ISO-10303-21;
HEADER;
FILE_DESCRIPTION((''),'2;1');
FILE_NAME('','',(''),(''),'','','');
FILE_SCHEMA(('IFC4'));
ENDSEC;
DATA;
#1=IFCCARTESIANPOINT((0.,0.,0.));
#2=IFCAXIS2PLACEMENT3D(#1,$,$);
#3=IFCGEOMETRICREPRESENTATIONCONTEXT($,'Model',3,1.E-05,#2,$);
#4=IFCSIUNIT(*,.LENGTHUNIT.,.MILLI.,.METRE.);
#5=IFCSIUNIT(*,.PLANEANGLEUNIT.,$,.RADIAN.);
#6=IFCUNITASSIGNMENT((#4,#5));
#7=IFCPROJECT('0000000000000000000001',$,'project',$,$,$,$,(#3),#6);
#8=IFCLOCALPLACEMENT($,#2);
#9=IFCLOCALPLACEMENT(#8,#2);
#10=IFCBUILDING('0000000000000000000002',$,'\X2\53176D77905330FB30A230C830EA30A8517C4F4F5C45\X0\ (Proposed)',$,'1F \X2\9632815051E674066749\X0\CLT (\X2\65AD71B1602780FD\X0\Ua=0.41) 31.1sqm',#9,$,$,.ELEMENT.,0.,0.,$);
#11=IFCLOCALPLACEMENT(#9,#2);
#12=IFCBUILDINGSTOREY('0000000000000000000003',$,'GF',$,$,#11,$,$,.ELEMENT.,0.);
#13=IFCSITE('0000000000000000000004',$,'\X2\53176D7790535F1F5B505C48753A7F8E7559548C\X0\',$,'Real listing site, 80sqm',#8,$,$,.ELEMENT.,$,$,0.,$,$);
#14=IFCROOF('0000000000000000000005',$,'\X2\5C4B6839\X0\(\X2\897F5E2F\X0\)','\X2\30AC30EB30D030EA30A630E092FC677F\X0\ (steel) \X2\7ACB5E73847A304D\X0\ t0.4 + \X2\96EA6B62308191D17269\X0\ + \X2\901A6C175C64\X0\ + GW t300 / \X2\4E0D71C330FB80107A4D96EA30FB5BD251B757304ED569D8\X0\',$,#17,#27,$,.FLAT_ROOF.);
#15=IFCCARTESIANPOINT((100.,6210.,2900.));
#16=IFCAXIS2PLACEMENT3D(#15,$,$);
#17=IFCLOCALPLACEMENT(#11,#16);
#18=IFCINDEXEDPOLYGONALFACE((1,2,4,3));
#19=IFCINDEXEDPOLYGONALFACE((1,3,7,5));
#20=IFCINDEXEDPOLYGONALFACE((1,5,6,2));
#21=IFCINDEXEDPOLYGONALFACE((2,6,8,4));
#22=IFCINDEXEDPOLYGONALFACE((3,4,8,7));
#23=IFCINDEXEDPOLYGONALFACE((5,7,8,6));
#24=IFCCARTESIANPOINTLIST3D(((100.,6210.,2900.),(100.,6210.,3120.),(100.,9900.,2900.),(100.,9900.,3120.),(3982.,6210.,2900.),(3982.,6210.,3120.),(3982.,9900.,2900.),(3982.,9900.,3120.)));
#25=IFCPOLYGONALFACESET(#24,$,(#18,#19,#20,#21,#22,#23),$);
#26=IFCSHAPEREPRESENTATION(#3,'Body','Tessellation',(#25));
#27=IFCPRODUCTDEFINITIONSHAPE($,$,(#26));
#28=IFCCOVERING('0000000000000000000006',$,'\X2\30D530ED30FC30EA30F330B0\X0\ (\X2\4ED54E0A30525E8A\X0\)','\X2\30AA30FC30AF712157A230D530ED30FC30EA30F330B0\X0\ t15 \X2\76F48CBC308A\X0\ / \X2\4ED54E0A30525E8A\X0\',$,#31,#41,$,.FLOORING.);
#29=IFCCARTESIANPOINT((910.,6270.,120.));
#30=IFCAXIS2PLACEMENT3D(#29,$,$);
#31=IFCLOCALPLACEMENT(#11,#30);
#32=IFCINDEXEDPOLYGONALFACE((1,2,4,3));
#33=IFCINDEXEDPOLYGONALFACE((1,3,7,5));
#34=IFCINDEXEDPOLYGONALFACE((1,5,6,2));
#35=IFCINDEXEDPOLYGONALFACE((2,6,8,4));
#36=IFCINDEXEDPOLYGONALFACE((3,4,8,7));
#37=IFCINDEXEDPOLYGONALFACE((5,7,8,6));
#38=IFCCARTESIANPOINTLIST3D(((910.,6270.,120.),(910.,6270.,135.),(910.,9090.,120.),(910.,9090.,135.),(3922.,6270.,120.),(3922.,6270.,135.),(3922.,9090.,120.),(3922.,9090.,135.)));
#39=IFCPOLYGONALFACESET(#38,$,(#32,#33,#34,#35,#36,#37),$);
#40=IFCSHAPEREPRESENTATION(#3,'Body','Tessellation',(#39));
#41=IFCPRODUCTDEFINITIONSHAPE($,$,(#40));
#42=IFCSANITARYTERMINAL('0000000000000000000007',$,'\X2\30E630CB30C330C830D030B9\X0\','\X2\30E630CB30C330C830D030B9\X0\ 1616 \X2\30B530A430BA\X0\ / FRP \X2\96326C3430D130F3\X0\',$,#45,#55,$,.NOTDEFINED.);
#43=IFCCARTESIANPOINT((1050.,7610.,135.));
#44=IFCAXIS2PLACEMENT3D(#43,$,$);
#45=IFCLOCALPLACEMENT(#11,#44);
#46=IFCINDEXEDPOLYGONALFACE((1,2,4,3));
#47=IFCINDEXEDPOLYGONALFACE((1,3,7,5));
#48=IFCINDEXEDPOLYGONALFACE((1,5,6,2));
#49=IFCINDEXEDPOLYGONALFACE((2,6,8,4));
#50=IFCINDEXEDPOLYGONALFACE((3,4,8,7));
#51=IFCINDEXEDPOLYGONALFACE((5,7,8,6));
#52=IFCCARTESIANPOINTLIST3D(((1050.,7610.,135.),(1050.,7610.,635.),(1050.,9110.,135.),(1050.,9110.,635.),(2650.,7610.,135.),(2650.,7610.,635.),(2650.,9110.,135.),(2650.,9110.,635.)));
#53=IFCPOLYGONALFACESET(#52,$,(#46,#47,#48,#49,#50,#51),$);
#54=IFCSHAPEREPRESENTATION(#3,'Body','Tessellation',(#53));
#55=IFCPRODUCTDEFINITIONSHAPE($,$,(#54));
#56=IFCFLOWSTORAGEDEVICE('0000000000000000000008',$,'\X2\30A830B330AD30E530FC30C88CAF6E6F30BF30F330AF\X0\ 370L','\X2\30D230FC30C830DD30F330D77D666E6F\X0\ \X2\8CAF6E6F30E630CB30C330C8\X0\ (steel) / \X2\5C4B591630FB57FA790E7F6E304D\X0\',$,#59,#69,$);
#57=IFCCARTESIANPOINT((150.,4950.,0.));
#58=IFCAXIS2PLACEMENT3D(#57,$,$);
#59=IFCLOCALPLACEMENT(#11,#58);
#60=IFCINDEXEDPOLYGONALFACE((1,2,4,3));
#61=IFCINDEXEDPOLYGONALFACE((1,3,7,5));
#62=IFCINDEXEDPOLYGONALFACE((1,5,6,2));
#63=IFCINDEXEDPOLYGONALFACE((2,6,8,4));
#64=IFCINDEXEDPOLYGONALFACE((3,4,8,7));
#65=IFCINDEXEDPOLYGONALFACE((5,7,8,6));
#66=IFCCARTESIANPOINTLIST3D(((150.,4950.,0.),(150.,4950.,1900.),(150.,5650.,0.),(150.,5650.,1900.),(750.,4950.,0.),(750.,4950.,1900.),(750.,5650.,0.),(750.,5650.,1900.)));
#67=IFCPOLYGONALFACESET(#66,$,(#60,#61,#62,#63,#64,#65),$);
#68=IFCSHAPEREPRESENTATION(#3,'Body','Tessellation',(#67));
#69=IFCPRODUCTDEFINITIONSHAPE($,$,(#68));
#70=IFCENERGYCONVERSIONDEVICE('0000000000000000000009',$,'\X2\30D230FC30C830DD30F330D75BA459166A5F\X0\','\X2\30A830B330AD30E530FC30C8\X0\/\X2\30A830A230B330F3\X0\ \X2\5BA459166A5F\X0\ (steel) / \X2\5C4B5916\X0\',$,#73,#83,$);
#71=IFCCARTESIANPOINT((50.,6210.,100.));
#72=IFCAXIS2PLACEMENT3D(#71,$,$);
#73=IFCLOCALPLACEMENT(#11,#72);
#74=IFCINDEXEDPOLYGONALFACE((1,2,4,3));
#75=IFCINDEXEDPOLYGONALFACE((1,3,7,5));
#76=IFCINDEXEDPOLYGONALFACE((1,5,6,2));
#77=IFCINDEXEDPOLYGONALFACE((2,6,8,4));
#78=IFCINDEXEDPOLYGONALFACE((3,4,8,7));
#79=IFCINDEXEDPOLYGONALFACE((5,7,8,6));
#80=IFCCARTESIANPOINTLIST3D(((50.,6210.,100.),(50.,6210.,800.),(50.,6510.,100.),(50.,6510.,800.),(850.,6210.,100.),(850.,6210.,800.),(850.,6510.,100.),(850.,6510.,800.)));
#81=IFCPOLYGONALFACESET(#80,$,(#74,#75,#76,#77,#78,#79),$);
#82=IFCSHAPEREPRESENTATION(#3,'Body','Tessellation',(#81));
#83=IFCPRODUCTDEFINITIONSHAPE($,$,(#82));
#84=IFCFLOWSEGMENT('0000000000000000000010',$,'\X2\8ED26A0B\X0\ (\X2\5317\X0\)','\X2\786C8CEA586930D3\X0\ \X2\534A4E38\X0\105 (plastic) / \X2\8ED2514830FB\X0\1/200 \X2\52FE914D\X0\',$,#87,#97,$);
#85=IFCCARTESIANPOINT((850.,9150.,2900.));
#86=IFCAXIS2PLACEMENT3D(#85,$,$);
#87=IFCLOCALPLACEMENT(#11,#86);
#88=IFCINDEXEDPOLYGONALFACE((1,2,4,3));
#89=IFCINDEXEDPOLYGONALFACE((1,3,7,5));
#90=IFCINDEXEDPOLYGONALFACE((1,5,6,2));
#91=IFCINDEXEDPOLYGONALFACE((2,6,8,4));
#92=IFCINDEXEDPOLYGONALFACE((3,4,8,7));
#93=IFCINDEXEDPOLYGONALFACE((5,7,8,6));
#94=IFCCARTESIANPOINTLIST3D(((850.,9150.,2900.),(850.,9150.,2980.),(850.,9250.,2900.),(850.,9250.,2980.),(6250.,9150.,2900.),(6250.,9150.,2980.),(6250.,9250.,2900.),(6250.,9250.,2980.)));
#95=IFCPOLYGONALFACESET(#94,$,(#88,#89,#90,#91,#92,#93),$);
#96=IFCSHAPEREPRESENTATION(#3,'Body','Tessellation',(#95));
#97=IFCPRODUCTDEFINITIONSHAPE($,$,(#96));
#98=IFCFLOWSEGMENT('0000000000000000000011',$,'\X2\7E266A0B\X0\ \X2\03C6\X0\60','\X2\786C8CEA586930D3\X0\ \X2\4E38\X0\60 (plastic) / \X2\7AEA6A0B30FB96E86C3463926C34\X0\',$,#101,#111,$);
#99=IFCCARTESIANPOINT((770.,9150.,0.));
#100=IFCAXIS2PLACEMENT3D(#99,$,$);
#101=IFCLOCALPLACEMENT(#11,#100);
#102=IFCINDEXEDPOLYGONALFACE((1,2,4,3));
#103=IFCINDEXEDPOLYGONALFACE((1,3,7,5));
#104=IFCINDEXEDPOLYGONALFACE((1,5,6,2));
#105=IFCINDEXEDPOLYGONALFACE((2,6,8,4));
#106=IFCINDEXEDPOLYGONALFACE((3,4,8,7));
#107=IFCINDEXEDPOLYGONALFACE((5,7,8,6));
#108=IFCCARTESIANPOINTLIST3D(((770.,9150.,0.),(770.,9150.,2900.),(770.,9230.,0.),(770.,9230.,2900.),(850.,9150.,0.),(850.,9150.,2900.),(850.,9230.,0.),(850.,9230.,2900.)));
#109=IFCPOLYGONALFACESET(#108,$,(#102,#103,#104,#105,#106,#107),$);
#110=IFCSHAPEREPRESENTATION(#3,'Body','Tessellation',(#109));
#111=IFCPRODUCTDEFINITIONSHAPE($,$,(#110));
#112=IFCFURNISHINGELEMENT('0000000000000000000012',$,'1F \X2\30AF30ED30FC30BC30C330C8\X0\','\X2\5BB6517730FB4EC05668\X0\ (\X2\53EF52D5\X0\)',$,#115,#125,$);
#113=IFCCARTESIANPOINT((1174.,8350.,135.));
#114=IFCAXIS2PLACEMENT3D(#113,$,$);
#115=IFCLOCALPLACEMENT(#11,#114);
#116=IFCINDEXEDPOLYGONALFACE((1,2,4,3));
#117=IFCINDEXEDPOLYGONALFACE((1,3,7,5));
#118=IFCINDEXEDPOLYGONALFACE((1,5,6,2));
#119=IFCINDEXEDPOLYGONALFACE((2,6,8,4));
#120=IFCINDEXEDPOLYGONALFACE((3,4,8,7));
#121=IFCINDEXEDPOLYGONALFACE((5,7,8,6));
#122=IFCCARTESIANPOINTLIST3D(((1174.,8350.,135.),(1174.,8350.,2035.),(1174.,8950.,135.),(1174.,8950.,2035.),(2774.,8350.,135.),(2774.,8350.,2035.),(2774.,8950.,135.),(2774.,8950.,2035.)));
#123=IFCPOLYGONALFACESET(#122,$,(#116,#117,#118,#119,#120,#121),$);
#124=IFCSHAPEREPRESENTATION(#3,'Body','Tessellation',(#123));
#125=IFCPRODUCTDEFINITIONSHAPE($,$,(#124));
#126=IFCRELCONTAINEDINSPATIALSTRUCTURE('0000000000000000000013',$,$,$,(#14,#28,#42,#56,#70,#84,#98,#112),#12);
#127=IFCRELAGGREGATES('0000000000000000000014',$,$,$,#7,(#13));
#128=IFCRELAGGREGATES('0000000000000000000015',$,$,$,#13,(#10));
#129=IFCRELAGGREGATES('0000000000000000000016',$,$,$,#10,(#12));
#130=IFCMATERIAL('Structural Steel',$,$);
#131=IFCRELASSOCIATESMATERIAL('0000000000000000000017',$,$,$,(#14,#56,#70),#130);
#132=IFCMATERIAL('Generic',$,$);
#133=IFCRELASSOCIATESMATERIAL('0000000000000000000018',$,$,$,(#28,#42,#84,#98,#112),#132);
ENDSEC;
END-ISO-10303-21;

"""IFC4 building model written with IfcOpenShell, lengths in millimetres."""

from ifc_helpers import new_model, si_unit, frame, frame_2d, origin, place, context, project, spatial, rectangle, extrude, material, element, save


model = new_model("IFC4")

# Units and contexts
model_context = context("Model", 3, precision=1e-05, world=origin())
ifc_project = project(units=[si_unit("LENGTHUNIT", "METRE", prefix="MILLI"), si_unit("PLANEANGLEUNIT", "RADIAN")], contexts=[model_context])

# Site, building, storey
site_placement = place(None, origin())
site = spatial("IfcSite", under=ifc_project, at=site_placement, Name="北海道弟子屈町美留和", ObjectType="Real listing site, 80sqm", CompositionType="ELEMENT", RefElevation=0.0)
building_placement = place(site_placement, origin())
building = spatial("IfcBuilding", under=site, at=building_placement, Name="北海道・アトリエ兼住居 (Proposed)", ObjectType="1F 防腐処理杉CLT (断熱性能Ua=0.41) 31.1sqm", CompositionType="ELEMENT", ElevationOfRefHeight=0.0, ElevationOfTerrain=0.0)
storey_placement = place(building_placement, origin())
storey = spatial("IfcBuildingStorey", under=building, at=storey_placement, Name="GF", CompositionType="ELEMENT", Elevation=0.0)

# Roof
ifc_material_1 = material(Name="Structural Steel")
roof_placement = place(storey_placement, frame((100.0, 6210.0, 2900.0)))
element("IfcRoof", 1, at=roof_placement, inside=storey, material=ifc_material_1, Name="屋根(西帯)", Description="ガルバリウム鋼板 (steel) 立平葺き t0.4 + 雪止め金物 + 通気層 + GW t300 / 不燃・耐積雪・寒冷地仕様", PredefinedType="FLAT_ROOF", context=model_context, shape_type="SweptSolid", body=[
    extrude(rectangle(XDim=3882.0, YDim=3690.0, at=frame_2d((1941.0, 1845.0))), frame((100.0, 6210.0, 2900.0)), (0.0, 0.0, 1.0), 220.0),
])

# Covering
ifc_material_2 = material(Name="Generic")
covering_placement = place(storey_placement, frame((910.0, 6270.0, 120.0)))
element("IfcCovering", 2, at=covering_placement, inside=storey, material=ifc_material_2, Name="フローリング (仕上げ床)", Description="オーク無垢フローリング t15 直貼り / 仕上げ床", PredefinedType="FLOORING", context=model_context, shape_type="SweptSolid", body=[
    extrude(rectangle(XDim=3012.0, YDim=2820.0, at=frame_2d((1506.0, 1410.0))), frame((910.0, 6270.0, 120.0)), (0.0, 0.0, 1.0), 15.0),
])

# Sanitary terminal
sanitary_terminal_placement = place(storey_placement, frame((1050.0, 7610.0, 135.0)))
element("IfcSanitaryTerminal", 3, at=sanitary_terminal_placement, inside=storey, material=ifc_material_2, Name="ユニットバス", Description="ユニットバス 1616 サイズ / FRP 防水パン", PredefinedType="NOTDEFINED", context=model_context, shape_type="SweptSolid", body=[
    extrude(rectangle(XDim=1600.0, YDim=1500.0, at=frame_2d((800.0, 750.0))), frame((1050.0, 7610.0, 135.0)), (0.0, 0.0, 1.0), 500.0),
])

# Flow storage device
flow_storage_device_placement = place(storey_placement, frame((150.0, 4950.0, 0.0)))
element("IfcFlowStorageDevice", 4, at=flow_storage_device_placement, inside=storey, material=ifc_material_1, Name="エコキュート貯湯タンク 370L", Description="ヒートポンプ給湯 貯湯ユニット (steel) / 屋外・基礎置き", context=model_context, shape_type="SweptSolid", body=[
    extrude(rectangle(XDim=600.0, YDim=700.0, at=frame_2d((300.0, 350.0))), frame((150.0, 4950.0, 0.0)), (0.0, 0.0, 1.0), 1900.0),
])

# Energy conversion device
energy_conversion_device_placement = place(storey_placement, frame((50.0, 6210.0, 100.0)))
element("IfcEnergyConversionDevice", 5, at=energy_conversion_device_placement, inside=storey, material=ifc_material_1, Name="ヒートポンプ室外機", Description="エコキュート/エアコン 室外機 (steel) / 屋外", context=model_context, shape_type="SweptSolid", body=[
    extrude(rectangle(XDim=800.0, YDim=300.0, at=frame_2d((400.0, 150.0))), frame((50.0, 6210.0, 100.0)), (0.0, 0.0, 1.0), 700.0),
])

# Flow segments
flow_segment_1_placement = place(storey_placement, frame((850.0, 9150.0, 2900.0)))
element("IfcFlowSegment", 6, at=flow_segment_1_placement, inside=storey, material=ifc_material_2, Name="軒樋 (北)", Description="硬質塩ビ 半丸105 (plastic) / 軒先・1/200 勾配", context=model_context, shape_type="SweptSolid", body=[
    extrude(rectangle(XDim=5400.0, YDim=100.0, at=frame_2d((2700.0, 50.0))), frame((850.0, 9150.0, 2900.0)), (0.0, 0.0, 1.0), 80.0),
])
flow_segment_2_placement = place(storey_placement, frame((770.0, 9150.0, 0.0)))
element("IfcFlowSegment", 7, at=flow_segment_2_placement, inside=storey, material=ifc_material_2, Name="縦樋 φ60", Description="硬質塩ビ 丸60 (plastic) / 竪樋・雨水排水", context=model_context, shape_type="SweptSolid", body=[
    extrude(rectangle(XDim=80.0, YDim=80.0, at=frame_2d((40.0, 40.0))), frame((770.0, 9150.0, 0.0)), (0.0, 0.0, 1.0), 2900.0),
])

# Furnishing element
furnishing_placement = place(storey_placement, frame((1174.0, 8350.0, 135.0)))
element("IfcFurnishingElement", 8, at=furnishing_placement, inside=storey, material=ifc_material_2, Name="1F クローゼット", Description="家具・什器 (可動)", context=model_context, shape_type="SweptSolid", body=[
    extrude(rectangle(XDim=1600.0, YDim=600.0, at=frame_2d((800.0, 300.0))), frame((1174.0, 8350.0, 135.0)), (0.0, 0.0, 1.0), 1900.0),
])

save(model, "model.ifc")
